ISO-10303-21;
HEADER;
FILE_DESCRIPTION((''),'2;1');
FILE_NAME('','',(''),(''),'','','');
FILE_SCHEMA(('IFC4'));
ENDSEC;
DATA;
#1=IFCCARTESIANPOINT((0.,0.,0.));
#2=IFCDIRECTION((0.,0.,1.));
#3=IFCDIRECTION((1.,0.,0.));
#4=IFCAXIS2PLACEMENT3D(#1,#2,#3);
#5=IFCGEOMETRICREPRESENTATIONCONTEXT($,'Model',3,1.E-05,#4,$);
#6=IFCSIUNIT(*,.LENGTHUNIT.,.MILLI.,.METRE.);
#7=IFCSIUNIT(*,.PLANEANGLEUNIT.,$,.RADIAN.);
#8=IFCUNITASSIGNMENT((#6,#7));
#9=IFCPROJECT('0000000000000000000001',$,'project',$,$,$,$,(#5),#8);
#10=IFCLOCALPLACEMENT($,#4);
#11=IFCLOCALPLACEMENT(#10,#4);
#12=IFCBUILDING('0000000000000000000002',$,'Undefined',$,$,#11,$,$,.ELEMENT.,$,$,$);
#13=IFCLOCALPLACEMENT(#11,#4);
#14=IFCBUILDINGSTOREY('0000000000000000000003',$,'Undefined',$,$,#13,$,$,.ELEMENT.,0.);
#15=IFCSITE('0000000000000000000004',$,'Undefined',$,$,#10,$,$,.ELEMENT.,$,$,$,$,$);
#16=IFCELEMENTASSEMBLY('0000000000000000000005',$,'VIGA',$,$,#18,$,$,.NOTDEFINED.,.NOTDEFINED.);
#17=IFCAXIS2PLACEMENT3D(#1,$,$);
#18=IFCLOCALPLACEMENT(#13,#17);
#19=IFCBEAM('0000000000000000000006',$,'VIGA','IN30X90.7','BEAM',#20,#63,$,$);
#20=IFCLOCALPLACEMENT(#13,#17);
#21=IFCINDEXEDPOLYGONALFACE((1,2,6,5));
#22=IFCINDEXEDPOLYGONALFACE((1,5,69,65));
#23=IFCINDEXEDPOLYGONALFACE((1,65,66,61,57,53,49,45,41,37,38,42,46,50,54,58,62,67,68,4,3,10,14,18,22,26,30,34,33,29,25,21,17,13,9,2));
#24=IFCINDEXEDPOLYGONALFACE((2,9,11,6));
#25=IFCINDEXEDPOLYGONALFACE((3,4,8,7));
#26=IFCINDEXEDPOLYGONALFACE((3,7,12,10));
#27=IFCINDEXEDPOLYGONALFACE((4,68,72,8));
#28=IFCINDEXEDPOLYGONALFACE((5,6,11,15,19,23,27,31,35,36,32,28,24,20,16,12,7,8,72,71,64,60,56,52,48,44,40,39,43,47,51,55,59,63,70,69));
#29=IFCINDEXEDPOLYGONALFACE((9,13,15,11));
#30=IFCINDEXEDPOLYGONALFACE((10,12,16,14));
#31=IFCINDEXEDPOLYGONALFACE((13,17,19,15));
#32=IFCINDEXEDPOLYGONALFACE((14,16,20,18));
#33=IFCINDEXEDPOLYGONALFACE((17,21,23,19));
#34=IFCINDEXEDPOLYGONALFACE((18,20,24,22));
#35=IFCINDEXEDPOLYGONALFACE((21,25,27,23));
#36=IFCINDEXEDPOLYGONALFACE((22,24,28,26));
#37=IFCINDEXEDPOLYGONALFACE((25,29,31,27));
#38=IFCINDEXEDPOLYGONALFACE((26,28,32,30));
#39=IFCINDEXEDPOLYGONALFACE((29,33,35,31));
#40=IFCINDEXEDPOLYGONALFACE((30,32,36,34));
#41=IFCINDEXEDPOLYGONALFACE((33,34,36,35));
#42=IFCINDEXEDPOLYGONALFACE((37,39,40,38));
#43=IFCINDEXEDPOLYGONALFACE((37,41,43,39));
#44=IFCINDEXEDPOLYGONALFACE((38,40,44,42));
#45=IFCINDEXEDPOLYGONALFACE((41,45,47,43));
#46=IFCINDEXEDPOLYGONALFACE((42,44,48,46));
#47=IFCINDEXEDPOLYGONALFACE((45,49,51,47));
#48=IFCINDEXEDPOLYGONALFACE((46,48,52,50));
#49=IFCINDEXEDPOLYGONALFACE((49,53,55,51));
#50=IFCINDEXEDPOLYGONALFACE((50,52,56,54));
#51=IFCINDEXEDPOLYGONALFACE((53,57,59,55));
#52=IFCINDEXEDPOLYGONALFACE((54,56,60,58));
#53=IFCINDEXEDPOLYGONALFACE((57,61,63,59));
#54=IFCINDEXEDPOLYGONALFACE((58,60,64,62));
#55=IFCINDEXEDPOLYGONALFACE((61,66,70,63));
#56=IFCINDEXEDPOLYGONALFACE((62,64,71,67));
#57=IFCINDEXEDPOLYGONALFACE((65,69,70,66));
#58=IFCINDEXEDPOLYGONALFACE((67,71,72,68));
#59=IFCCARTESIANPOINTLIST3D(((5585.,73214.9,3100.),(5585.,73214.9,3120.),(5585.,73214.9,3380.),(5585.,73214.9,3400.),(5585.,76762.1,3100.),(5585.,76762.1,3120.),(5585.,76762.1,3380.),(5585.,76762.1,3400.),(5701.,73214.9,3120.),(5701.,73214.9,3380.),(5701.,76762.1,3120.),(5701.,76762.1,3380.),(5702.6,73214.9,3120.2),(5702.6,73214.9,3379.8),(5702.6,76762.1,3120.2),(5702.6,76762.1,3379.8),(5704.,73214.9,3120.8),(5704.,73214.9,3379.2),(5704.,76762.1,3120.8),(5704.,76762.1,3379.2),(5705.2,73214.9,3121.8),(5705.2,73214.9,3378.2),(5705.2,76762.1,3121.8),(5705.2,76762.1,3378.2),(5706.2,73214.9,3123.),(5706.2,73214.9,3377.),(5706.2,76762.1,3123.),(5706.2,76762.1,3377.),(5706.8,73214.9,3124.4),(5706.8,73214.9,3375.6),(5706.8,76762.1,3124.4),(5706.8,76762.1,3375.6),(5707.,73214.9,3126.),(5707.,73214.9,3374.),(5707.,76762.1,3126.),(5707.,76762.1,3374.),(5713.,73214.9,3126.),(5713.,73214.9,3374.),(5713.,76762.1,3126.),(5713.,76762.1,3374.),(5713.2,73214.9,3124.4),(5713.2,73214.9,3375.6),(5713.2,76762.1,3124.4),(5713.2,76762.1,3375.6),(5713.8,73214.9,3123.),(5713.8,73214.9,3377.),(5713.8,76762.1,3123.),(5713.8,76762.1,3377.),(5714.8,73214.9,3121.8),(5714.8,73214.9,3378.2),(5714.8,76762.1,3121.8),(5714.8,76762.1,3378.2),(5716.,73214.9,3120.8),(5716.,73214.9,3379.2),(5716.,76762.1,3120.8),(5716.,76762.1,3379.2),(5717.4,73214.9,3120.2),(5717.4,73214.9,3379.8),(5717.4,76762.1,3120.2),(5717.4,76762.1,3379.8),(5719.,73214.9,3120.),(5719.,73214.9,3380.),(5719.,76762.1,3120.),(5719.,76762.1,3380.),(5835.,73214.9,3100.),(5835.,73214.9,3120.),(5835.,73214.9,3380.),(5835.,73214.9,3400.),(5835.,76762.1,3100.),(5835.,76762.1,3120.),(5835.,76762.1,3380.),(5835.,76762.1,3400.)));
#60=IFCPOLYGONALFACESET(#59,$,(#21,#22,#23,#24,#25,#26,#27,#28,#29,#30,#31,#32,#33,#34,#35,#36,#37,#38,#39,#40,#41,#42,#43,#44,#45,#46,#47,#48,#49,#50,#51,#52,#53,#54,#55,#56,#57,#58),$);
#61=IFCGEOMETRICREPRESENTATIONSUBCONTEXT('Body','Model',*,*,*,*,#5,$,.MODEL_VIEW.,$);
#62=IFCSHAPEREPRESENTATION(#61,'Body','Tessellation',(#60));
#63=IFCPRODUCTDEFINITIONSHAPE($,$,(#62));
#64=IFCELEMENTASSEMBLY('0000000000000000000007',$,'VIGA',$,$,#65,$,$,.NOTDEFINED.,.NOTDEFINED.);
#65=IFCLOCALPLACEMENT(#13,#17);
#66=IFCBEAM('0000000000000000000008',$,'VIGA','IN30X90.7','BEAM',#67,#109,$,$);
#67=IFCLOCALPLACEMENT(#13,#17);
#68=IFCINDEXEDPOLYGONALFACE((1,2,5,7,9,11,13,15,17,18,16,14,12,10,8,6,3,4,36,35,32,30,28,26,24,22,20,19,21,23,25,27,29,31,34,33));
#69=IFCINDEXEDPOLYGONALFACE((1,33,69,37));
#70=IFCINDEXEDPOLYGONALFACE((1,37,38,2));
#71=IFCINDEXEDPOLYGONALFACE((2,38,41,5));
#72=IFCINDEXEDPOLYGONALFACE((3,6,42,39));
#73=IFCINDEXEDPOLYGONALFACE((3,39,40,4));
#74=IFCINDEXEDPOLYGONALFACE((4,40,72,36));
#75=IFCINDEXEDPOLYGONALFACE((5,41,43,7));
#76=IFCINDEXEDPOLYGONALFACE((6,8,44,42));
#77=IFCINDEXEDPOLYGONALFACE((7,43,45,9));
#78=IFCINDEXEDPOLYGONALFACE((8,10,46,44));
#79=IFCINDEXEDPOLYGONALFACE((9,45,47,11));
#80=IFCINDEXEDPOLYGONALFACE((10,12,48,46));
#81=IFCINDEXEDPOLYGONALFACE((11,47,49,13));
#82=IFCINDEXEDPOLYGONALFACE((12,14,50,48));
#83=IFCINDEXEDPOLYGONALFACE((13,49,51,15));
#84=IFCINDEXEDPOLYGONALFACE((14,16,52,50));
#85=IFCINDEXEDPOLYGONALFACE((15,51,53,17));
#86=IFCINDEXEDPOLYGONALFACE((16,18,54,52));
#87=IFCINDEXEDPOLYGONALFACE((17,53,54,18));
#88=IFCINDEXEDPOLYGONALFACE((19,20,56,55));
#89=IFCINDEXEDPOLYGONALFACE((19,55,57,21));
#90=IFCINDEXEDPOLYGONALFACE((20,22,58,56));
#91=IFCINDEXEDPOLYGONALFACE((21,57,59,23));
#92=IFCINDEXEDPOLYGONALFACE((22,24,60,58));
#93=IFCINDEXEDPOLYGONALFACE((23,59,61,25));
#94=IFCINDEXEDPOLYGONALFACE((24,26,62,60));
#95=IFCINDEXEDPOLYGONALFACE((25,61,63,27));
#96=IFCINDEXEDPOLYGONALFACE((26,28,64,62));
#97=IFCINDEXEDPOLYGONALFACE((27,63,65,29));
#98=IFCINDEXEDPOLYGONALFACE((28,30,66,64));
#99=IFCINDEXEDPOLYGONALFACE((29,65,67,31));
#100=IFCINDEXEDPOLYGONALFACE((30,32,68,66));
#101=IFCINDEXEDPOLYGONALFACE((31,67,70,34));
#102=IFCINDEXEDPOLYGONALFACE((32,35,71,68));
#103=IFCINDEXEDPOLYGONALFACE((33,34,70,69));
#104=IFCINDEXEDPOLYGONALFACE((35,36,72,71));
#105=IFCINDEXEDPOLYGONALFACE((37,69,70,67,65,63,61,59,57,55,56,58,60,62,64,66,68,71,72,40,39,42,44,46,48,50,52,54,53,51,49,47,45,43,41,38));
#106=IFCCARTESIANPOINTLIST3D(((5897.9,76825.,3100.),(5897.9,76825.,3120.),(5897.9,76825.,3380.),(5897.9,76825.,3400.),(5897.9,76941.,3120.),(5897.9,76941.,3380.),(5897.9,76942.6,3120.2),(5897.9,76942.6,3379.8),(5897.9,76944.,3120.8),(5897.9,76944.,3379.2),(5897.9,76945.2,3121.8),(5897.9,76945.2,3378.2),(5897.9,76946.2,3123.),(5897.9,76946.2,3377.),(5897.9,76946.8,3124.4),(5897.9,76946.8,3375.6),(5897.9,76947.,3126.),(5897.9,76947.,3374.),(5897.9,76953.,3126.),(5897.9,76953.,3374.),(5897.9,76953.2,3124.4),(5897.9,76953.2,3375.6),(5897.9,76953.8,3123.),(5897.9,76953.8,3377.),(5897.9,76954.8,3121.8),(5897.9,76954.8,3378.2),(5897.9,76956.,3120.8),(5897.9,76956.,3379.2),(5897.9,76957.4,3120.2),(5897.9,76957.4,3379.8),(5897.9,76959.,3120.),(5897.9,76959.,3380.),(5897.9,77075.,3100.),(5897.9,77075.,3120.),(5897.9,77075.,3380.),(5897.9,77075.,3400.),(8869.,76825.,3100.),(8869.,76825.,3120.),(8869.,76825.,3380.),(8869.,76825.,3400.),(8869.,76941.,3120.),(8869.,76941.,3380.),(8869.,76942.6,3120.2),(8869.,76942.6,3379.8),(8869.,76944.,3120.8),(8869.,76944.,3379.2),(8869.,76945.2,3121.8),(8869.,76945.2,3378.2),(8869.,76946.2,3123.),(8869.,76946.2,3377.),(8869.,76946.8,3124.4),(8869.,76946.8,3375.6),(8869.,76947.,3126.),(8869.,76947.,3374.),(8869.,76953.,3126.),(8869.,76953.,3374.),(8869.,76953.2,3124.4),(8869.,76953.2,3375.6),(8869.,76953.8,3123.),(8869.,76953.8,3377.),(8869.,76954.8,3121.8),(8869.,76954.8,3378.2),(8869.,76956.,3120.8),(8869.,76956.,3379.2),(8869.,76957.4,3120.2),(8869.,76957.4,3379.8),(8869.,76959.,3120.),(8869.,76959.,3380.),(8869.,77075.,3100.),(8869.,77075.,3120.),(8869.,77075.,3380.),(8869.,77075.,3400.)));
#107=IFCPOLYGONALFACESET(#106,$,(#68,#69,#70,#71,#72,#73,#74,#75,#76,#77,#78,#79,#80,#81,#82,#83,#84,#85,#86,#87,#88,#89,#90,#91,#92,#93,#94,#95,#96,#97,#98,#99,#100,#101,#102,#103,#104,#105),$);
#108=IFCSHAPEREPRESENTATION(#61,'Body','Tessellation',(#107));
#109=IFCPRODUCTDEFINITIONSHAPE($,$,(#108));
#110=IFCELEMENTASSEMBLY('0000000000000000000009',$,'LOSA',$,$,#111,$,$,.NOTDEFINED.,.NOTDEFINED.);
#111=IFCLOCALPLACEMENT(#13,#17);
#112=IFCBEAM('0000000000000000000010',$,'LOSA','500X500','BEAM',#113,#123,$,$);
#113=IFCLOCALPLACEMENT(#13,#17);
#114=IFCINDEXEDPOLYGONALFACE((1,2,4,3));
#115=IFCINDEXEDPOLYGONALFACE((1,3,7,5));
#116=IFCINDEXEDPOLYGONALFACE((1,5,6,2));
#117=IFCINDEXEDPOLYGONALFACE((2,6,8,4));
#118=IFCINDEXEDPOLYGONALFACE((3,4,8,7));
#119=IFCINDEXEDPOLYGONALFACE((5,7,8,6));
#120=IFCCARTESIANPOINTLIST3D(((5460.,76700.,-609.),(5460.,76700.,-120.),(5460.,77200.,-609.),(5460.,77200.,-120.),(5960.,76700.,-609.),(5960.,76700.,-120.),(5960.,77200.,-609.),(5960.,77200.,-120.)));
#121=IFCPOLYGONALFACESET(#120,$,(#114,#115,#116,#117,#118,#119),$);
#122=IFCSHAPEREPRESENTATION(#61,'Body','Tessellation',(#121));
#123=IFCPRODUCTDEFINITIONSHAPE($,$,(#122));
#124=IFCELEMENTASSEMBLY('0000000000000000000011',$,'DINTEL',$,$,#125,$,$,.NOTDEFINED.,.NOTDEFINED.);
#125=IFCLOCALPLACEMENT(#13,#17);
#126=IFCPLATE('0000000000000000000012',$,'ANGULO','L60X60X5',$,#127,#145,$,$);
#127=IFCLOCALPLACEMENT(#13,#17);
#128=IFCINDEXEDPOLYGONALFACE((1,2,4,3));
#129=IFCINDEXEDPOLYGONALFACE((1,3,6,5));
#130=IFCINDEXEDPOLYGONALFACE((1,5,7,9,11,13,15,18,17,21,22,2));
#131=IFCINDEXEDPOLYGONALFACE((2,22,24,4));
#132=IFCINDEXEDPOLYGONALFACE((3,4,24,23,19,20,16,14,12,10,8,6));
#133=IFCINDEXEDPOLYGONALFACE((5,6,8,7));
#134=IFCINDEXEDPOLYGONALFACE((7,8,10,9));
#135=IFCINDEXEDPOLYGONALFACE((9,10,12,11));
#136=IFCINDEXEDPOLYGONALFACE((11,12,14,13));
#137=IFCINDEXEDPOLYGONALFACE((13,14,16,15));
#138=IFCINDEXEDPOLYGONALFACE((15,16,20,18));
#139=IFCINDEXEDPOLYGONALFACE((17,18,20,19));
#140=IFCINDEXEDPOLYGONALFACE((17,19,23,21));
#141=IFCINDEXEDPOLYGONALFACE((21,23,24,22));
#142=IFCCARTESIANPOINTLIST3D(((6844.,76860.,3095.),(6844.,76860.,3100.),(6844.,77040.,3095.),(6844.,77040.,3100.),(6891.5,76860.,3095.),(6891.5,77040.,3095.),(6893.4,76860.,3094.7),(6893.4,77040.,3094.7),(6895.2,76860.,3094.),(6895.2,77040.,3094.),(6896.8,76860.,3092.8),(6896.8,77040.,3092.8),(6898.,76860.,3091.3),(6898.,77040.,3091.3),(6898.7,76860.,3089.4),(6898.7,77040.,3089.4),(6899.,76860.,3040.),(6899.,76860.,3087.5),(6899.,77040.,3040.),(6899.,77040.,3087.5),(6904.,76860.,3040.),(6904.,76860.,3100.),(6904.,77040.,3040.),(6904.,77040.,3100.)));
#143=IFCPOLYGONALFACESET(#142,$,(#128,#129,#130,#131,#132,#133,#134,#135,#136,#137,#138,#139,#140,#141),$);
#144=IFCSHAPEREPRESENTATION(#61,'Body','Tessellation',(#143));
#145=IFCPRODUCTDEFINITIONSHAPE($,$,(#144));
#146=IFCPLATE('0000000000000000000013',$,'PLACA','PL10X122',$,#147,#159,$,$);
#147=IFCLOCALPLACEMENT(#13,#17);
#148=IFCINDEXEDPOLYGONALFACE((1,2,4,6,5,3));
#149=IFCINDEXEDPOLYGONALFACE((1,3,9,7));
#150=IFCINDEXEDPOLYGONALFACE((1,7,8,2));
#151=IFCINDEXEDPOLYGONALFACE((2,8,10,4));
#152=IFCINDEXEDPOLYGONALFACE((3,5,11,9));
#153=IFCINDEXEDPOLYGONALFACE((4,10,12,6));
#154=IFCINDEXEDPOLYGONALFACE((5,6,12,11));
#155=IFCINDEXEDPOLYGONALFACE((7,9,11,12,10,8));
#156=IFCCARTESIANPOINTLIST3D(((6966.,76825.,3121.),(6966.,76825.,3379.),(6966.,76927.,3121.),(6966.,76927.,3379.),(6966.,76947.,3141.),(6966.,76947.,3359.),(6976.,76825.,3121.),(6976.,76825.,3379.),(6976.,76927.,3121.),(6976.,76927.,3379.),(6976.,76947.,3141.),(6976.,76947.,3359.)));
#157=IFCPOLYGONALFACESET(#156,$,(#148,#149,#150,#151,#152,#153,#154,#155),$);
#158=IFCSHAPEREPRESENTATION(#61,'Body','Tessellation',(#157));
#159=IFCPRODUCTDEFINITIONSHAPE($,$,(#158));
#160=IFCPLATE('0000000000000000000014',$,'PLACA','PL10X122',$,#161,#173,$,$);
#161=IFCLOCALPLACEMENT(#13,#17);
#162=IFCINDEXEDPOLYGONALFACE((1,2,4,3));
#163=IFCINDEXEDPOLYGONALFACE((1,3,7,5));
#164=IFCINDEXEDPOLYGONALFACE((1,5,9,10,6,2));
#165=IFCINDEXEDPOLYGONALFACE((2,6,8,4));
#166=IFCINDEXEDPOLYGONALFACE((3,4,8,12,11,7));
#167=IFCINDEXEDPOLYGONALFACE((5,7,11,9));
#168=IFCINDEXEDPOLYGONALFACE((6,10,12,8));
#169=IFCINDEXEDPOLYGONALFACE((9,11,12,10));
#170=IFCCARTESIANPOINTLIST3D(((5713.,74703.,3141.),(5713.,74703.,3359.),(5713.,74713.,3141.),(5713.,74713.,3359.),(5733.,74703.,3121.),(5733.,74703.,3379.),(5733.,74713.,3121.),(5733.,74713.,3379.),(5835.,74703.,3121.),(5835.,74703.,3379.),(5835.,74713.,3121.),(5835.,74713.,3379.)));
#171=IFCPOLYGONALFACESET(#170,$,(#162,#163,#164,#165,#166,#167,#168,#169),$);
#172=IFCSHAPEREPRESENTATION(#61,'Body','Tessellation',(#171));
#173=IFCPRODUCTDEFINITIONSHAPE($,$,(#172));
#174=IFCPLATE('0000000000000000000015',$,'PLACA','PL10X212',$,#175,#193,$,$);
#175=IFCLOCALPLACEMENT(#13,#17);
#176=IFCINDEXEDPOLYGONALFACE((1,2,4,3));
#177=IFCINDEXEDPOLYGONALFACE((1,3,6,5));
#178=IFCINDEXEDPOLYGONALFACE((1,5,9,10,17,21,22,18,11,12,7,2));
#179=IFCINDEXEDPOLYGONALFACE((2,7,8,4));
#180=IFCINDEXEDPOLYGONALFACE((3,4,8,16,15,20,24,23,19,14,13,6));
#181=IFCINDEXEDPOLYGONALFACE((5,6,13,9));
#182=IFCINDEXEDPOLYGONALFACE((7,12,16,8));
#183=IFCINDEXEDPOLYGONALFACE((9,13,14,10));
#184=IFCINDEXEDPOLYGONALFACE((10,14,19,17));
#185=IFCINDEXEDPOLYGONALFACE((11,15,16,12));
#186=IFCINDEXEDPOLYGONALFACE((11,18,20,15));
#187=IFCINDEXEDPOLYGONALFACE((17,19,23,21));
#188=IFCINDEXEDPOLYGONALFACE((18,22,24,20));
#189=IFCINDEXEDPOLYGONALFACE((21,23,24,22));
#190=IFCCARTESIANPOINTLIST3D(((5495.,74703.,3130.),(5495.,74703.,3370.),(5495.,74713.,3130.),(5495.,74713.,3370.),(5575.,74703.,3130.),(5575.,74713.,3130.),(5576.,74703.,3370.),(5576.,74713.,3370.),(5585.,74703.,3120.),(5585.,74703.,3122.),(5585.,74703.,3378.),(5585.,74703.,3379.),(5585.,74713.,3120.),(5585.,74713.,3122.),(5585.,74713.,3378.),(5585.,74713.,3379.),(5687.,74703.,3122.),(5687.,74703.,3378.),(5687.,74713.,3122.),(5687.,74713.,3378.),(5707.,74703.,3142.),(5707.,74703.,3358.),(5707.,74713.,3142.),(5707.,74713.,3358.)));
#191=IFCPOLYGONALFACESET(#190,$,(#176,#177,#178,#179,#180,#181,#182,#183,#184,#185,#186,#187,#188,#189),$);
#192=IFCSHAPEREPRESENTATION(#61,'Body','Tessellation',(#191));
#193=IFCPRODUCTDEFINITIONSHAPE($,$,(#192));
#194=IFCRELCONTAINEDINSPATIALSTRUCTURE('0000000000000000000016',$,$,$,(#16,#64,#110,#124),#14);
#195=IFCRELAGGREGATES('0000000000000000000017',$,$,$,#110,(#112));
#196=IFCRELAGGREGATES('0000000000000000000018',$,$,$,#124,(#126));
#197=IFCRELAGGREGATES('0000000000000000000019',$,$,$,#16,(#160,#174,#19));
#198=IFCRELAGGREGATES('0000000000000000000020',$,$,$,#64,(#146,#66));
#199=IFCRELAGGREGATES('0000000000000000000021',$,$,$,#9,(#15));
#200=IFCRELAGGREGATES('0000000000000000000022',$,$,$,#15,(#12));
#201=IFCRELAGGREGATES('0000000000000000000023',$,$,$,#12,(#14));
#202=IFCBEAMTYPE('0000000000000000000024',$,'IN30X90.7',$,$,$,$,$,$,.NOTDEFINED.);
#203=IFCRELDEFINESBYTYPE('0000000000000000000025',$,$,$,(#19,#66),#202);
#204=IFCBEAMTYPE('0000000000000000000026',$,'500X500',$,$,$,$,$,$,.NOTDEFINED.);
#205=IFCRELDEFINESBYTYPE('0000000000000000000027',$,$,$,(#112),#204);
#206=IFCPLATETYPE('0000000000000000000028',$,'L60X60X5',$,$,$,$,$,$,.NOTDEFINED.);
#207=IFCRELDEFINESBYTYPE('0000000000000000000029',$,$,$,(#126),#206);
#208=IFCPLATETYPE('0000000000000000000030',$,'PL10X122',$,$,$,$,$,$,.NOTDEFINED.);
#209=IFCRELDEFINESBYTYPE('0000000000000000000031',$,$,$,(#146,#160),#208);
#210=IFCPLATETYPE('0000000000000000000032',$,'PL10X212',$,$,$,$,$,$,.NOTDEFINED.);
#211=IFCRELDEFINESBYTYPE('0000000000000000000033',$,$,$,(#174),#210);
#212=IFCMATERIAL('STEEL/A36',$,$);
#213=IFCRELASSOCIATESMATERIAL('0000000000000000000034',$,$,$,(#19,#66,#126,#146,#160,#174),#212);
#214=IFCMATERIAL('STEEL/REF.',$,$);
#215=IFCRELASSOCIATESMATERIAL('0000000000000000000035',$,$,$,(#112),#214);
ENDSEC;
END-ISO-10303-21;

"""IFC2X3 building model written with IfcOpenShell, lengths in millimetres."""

from ifc_helpers import new_model, si_unit, frame, origin_with_axes, origin_2d_with_axis, place, context, subcontext, project, spatial, polyline, rectangle, i_section, l_section, outline, extrude, clip, halfspace, material, type_object, element, aggregate, save


model = new_model("IFC2X3")

# Units and contexts
model_context = context("Model", 3, precision=1e-05, world=origin_with_axes())
body_context = subcontext(model_context, "Body", "Model", "MODEL_VIEW")
ifc_project = project(units=[si_unit("LENGTHUNIT", "METRE", prefix="MILLI"), si_unit("PLANEANGLEUNIT", "RADIAN")], contexts=[model_context])

# Site, building, storey
site_placement = place(None, origin_with_axes())
site = spatial("IfcSite", under=ifc_project, at=site_placement, Name="Undefined", CompositionType="ELEMENT")
building_placement = place(site_placement, origin_with_axes())
building = spatial("IfcBuilding", under=site, at=building_placement, Name="Undefined", CompositionType="ELEMENT")
storey_placement = place(building_placement, origin_with_axes())
storey = spatial("IfcBuildingStorey", under=building, at=storey_placement, Name="Undefined", CompositionType="ELEMENT", Elevation=0.0)

# Element assemblies, beams
assembly_1_placement = place(storey_placement, origin_with_axes())
assembly_1 = element("IfcElementAssembly", 1, at=assembly_1_placement, inside=storey, Name="VIGA", AssemblyPlace="NOTDEFINED", PredefinedType="NOTDEFINED")
ifc_material_1 = material(Name="STEEL/A36")
beam_type_1 = type_object("IfcBeamType", Name="IN30X90.7", PredefinedType="NOTDEFINED")
beam_1_placement = place(assembly_1_placement, frame((5710.0, 76762.1, 3250.0), z_axis=(0.0, 0.0, 1.0), x_axis=(0.0, -1.0, 0.0)))
beam_1 = element("IfcBeam", 2, at=beam_1_placement, type_object=beam_type_1, material=ifc_material_1, Name="VIGA", Description="IN30X90.7", ObjectType="BEAM", context=body_context, shape_type="SweptSolid", body=[
    extrude(i_section(OverallWidth=250.0, OverallDepth=300.0, WebThickness=6.0, FlangeThickness=20.0, FilletRadius=6.0, at=origin_2d_with_axis()), frame((3547.2, 0.0, 0.0), z_axis=(-1.0, 0.0, 0.0), x_axis=(0.0, -1.0, 0.0)), (0.0, 0.0, 1.0), 3547.2),
])
assembly_2_placement = place(storey_placement, origin_with_axes())
assembly_2 = element("IfcElementAssembly", 3, at=assembly_2_placement, inside=storey, Name="VIGA", AssemblyPlace="NOTDEFINED", PredefinedType="NOTDEFINED")
beam_2_placement = place(assembly_2_placement, frame((5897.9, 76950.0, 3250.0), z_axis=(0.0, 0.0, 1.0), x_axis=(1.0, 0.0, 0.0)))
beam_2 = element("IfcBeam", 4, at=beam_2_placement, type_object=beam_type_1, material=ifc_material_1, Name="VIGA", Description="IN30X90.7", ObjectType="BEAM", context=body_context, shape_type="Clipping", body=[
    clip(extrude(i_section(OverallWidth=250.0, OverallDepth=300.0, WebThickness=6.0, FlangeThickness=20.0, FilletRadius=6.0, at=origin_2d_with_axis()), frame((2981.1, 0.0, 0.0), z_axis=(-1.0, 0.0, 0.0), x_axis=(0.0, -1.0, 0.0)), (0.0, 0.0, 1.0), 2981.1), halfspace(frame((2971.1, 0.0, 250.0), z_axis=(1.0, 0.0, 0.0), x_axis=(0.0, 1.0, 0.0)), False)),
])
assembly_3_placement = place(storey_placement, origin_with_axes())
assembly_3 = element("IfcElementAssembly", 5, at=assembly_3_placement, inside=storey, Name="LOSA", AssemblyPlace="NOTDEFINED", PredefinedType="NOTDEFINED")
ifc_material_2 = material(Name="STEEL/REF.")
beam_type_2 = type_object("IfcBeamType", Name="500X500", PredefinedType="NOTDEFINED")
beam_3_placement = place(assembly_3_placement, frame((5710.0, 76950.0, -120.0), z_axis=(1.0, 0.0, 0.0), x_axis=(0.0, 0.0, -1.0)))
beam_3 = element("IfcBeam", 6, at=beam_3_placement, type_object=beam_type_2, material=ifc_material_2, Name="LOSA", Description="500X500", ObjectType="BEAM", context=body_context, shape_type="SweptSolid", body=[
    extrude(rectangle(XDim=500.0, YDim=500.0, at=origin_2d_with_axis()), frame((489.0, 0.0, 0.0), z_axis=(-1.0, 0.0, 0.0), x_axis=(0.0, -1.0, 0.0)), (0.0, 0.0, 1.0), 489.0),
])
aggregate(assembly_3, [beam_3])

# Element assembly, plate
assembly_4_placement = place(storey_placement, origin_with_axes())
assembly_4 = element("IfcElementAssembly", 7, at=assembly_4_placement, inside=storey, Name="DINTEL", AssemblyPlace="NOTDEFINED", PredefinedType="NOTDEFINED")
plate_type_1 = type_object("IfcPlateType", Name="L60X60X5", PredefinedType="NOTDEFINED")
plate_1_placement = place(assembly_4_placement, frame((6874.0, 76860.0, 3070.0), z_axis=(0.0, 0.0, -1.0), x_axis=(0.0, 1.0, 0.0)))
plate_1 = element("IfcPlate", 8, at=plate_1_placement, type_object=plate_type_1, material=ifc_material_1, Name="ANGULO", Description="L60X60X5", context=body_context, shape_type="SweptSolid", body=[
    extrude(l_section(Depth=60.0, Width=60.0, Thickness=5.0, FilletRadius=7.5, at=origin_2d_with_axis()), frame((180.0, 0.0, 0.0), z_axis=(-1.0, 0.0, 0.0), x_axis=(0.0, -1.0, 0.0)), (0.0, 0.0, 1.0), 180.0),
])
aggregate(assembly_4, [plate_1])

# Plates
plate_type_2 = type_object("IfcPlateType", Name="PL10X122", PredefinedType="NOTDEFINED")
plate_2_placement = place(assembly_2_placement, frame((6971.0, 76947.0, 3121.0), z_axis=(-1.0, 0.0, 0.0), x_axis=(0.0, -1.0, 0.0)))
plate_2 = element("IfcPlate", 9, at=plate_2_placement, type_object=plate_type_2, material=ifc_material_1, Name="PLACA", Description="PL10X122", context=body_context, shape_type="SweptSolid", body=[
    extrude(outline(polyline([(0.0, 20.0), (20.0, 0.0), (122.0, 0.0), (122.0, 258.0), (20.0, 258.0), (0.0, 238.0), (0.0, 20.0)])), frame((0.0, 0.0, -5.0), z_axis=(0.0, 0.0, 1.0), x_axis=(1.0, 0.0, 0.0)), (0.0, 0.0, 1.0), 10.0),
])
plate_3_placement = place(assembly_1_placement, frame((5713.0, 74708.0, 3121.0), z_axis=(0.0, -1.0, 0.0), x_axis=(1.0, 0.0, 0.0)))
plate_3 = element("IfcPlate", 10, at=plate_3_placement, type_object=plate_type_2, material=ifc_material_1, Name="PLACA", Description="PL10X122", context=body_context, shape_type="SweptSolid", body=[
    extrude(outline(polyline([(0.0, 20.0), (20.0, 0.0), (122.0, 0.0), (122.0, 258.0), (20.0, 258.0), (0.0, 238.0), (0.0, 20.0)])), frame((0.0, 0.0, -5.0), z_axis=(0.0, 0.0, 1.0), x_axis=(1.0, 0.0, 0.0)), (0.0, 0.0, 1.0), 10.0),
])
plate_type_3 = type_object("IfcPlateType", Name="PL10X212", PredefinedType="NOTDEFINED")
plate_4_placement = place(assembly_1_placement, frame((5707.0, 74708.0, 3142.0), z_axis=(0.0, 1.0, 0.0), x_axis=(-0.707107, 0.0, -0.707107)))
plate_4 = element("IfcPlate", 11, at=plate_4_placement, type_object=plate_type_3, material=ifc_material_1, Name="PLACA", Description="PL10X212", context=body_context, shape_type="SweptSolid", body=[
    extrude(outline(polyline([(0.0, 0.0), (28.3, 0.0), (100.4, 72.1), (101.8, 70.7), (101.8, 84.9), (158.4, 141.4), (-11.3, 311.1), (-68.6, 253.9), (-81.3, 253.9), (-80.6, 253.1), (-152.7, 181.0), (-152.7, 152.7), (0.0, 0.0)])), frame((0.0, 0.0, -5.0), z_axis=(0.0, 0.0, 1.0), x_axis=(1.0, 0.0, 0.0)), (0.0, 0.0, 1.0), 10.0),
])
aggregate(assembly_1, [plate_3, plate_4, beam_1])

aggregate(assembly_2, [plate_2, beam_2])

save(model, "model.ifc")
